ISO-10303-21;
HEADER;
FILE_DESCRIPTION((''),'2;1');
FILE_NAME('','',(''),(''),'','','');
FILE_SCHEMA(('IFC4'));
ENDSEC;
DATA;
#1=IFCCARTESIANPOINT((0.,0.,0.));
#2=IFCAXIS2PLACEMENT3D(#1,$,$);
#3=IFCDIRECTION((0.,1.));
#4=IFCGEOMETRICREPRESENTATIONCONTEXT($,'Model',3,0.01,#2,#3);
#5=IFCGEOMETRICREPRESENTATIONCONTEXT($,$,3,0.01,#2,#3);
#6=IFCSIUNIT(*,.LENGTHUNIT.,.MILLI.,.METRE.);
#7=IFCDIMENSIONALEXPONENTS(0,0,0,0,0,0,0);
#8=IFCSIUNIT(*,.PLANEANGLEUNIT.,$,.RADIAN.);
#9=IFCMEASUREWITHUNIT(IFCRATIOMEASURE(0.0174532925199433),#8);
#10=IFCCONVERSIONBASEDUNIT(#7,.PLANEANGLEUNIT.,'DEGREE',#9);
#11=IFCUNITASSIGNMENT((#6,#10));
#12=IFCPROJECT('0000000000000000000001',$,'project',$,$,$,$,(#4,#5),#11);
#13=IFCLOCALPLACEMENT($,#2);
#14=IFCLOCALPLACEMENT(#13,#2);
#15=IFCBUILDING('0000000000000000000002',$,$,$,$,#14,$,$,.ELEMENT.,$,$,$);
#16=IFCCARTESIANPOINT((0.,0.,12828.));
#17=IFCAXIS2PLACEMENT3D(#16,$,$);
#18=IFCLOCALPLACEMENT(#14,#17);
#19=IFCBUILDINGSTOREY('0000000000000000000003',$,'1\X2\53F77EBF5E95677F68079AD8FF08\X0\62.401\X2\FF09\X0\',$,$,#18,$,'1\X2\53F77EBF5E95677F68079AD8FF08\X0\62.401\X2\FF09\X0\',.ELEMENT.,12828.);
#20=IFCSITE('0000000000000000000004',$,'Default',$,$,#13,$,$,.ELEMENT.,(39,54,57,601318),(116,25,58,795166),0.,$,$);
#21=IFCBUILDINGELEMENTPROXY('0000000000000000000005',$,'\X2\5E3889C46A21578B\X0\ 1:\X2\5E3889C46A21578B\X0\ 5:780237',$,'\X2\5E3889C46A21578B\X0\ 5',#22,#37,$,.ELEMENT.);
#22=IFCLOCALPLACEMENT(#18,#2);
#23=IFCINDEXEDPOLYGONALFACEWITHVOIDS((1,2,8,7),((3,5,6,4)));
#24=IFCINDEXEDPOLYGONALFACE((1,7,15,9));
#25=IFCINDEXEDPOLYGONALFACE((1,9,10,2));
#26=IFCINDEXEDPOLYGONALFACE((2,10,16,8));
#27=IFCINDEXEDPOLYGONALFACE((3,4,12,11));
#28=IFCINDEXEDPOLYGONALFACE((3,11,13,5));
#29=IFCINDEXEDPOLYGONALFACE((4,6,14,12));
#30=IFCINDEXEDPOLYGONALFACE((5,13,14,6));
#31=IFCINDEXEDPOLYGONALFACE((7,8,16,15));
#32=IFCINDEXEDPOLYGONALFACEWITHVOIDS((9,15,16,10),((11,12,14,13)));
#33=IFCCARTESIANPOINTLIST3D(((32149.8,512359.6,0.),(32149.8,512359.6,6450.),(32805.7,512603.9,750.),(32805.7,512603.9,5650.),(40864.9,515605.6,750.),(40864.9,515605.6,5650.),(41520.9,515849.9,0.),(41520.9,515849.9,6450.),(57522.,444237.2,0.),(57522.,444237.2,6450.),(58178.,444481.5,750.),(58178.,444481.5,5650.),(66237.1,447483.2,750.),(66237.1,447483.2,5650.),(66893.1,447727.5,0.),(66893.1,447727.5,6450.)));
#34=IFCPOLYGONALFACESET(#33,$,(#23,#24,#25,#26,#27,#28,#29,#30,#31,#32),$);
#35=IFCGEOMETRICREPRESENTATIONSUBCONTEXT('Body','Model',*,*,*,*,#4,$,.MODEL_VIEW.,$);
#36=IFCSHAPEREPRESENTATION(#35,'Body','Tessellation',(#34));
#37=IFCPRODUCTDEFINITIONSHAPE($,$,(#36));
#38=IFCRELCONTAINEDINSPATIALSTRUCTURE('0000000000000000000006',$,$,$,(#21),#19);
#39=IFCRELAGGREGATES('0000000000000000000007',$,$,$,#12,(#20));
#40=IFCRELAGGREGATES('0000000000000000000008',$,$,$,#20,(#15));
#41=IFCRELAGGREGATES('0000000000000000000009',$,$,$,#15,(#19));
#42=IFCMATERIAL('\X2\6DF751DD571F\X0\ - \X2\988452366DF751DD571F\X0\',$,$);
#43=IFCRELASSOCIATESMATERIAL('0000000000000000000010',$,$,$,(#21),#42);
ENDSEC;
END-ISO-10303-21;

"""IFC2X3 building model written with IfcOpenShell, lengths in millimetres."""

from ifc_helpers import new_model, entity, si_unit, converted_unit, direction, frame, origin, place, context, subcontext, project, spatial, polyline, outline, extrude, source, transform, mapped, material, element, save


model = new_model("IFC2X3")

# Units and contexts
model_context = context("Model", 3, precision=0.01, world=origin(), true_north=direction((0.0, 1.0)))
context_of_model = context(None, 3, precision=0.01, world=origin(), true_north=direction((0.0, 1.0)))
body_context = subcontext(model_context, "Body", "Model", "MODEL_VIEW")
ifc_project = project(units=[si_unit("LENGTHUNIT", "METRE", prefix="MILLI"), converted_unit("PLANEANGLEUNIT", "DEGREE", entity("IfcRatioMeasure", 0.0174532925199433), si_unit("PLANEANGLEUNIT", "RADIAN"), dimensions=[0, 0, 0, 0, 0, 0, 0])], contexts=[model_context, context_of_model])

# Site, building, storey
site_placement = place(None, origin())
site = spatial("IfcSite", under=ifc_project, at=site_placement, Name="Default", CompositionType="ELEMENT", RefLatitude=(39, 54, 57, 601318), RefLongitude=(116, 25, 58, 795166), RefElevation=0.0)
building_placement = place(site_placement, origin())
building = spatial("IfcBuilding", under=site, at=building_placement, CompositionType="ELEMENT")
storey_placement = place(building_placement, frame((0.0, 0.0, 12828.0)))
storey = spatial("IfcBuildingStorey", under=building, at=storey_placement, Name="1号线底板标高（62.401）", LongName="1号线底板标高（62.401）", CompositionType="ELEMENT", Elevation=12828.0)

# Building element proxy
ifc_material_1 = material(Name="混凝土 - 预制混凝土")
shared_shape_1 = source(origin(), body_context, "Body", "SweptSolid", [
    extrude(outline(polyline([(-3225.0, -5000.0), (3225.0, -5000.0), (3225.0, 5000.0), (-3225.0, 5000.0), (-3225.0, -5000.0)]), holes=[polyline([(-2475.0, 4300.0), (2425.0, 4300.0), (2425.0, -4300.0), (-2475.0, -4300.0), (-2475.0, 4300.0)])]), frame((30057.8, 1745.1, 3225.0), z_axis=(-0.349028, 0.937112, 0.0), x_axis=(0.0, 0.0, 1.0)), (0.0, 0.0, 1.0), 72693.9),
])
proxy_placement = place(storey_placement, frame((32149.8, 444237.2, 0.0)))
element("IfcBuildingElementProxy", 1, at=proxy_placement, inside=storey, material=ifc_material_1, Name="常规模型 1:常规模型 5:780237", ObjectType="常规模型 5", CompositionType="ELEMENT", context=body_context, shape_type="MappedRepresentation", body=[
    mapped(shared_shape_1, transform((0.0, 0.0, 0.0), scale=1.0)),
])

save(model, "model.ifc")
